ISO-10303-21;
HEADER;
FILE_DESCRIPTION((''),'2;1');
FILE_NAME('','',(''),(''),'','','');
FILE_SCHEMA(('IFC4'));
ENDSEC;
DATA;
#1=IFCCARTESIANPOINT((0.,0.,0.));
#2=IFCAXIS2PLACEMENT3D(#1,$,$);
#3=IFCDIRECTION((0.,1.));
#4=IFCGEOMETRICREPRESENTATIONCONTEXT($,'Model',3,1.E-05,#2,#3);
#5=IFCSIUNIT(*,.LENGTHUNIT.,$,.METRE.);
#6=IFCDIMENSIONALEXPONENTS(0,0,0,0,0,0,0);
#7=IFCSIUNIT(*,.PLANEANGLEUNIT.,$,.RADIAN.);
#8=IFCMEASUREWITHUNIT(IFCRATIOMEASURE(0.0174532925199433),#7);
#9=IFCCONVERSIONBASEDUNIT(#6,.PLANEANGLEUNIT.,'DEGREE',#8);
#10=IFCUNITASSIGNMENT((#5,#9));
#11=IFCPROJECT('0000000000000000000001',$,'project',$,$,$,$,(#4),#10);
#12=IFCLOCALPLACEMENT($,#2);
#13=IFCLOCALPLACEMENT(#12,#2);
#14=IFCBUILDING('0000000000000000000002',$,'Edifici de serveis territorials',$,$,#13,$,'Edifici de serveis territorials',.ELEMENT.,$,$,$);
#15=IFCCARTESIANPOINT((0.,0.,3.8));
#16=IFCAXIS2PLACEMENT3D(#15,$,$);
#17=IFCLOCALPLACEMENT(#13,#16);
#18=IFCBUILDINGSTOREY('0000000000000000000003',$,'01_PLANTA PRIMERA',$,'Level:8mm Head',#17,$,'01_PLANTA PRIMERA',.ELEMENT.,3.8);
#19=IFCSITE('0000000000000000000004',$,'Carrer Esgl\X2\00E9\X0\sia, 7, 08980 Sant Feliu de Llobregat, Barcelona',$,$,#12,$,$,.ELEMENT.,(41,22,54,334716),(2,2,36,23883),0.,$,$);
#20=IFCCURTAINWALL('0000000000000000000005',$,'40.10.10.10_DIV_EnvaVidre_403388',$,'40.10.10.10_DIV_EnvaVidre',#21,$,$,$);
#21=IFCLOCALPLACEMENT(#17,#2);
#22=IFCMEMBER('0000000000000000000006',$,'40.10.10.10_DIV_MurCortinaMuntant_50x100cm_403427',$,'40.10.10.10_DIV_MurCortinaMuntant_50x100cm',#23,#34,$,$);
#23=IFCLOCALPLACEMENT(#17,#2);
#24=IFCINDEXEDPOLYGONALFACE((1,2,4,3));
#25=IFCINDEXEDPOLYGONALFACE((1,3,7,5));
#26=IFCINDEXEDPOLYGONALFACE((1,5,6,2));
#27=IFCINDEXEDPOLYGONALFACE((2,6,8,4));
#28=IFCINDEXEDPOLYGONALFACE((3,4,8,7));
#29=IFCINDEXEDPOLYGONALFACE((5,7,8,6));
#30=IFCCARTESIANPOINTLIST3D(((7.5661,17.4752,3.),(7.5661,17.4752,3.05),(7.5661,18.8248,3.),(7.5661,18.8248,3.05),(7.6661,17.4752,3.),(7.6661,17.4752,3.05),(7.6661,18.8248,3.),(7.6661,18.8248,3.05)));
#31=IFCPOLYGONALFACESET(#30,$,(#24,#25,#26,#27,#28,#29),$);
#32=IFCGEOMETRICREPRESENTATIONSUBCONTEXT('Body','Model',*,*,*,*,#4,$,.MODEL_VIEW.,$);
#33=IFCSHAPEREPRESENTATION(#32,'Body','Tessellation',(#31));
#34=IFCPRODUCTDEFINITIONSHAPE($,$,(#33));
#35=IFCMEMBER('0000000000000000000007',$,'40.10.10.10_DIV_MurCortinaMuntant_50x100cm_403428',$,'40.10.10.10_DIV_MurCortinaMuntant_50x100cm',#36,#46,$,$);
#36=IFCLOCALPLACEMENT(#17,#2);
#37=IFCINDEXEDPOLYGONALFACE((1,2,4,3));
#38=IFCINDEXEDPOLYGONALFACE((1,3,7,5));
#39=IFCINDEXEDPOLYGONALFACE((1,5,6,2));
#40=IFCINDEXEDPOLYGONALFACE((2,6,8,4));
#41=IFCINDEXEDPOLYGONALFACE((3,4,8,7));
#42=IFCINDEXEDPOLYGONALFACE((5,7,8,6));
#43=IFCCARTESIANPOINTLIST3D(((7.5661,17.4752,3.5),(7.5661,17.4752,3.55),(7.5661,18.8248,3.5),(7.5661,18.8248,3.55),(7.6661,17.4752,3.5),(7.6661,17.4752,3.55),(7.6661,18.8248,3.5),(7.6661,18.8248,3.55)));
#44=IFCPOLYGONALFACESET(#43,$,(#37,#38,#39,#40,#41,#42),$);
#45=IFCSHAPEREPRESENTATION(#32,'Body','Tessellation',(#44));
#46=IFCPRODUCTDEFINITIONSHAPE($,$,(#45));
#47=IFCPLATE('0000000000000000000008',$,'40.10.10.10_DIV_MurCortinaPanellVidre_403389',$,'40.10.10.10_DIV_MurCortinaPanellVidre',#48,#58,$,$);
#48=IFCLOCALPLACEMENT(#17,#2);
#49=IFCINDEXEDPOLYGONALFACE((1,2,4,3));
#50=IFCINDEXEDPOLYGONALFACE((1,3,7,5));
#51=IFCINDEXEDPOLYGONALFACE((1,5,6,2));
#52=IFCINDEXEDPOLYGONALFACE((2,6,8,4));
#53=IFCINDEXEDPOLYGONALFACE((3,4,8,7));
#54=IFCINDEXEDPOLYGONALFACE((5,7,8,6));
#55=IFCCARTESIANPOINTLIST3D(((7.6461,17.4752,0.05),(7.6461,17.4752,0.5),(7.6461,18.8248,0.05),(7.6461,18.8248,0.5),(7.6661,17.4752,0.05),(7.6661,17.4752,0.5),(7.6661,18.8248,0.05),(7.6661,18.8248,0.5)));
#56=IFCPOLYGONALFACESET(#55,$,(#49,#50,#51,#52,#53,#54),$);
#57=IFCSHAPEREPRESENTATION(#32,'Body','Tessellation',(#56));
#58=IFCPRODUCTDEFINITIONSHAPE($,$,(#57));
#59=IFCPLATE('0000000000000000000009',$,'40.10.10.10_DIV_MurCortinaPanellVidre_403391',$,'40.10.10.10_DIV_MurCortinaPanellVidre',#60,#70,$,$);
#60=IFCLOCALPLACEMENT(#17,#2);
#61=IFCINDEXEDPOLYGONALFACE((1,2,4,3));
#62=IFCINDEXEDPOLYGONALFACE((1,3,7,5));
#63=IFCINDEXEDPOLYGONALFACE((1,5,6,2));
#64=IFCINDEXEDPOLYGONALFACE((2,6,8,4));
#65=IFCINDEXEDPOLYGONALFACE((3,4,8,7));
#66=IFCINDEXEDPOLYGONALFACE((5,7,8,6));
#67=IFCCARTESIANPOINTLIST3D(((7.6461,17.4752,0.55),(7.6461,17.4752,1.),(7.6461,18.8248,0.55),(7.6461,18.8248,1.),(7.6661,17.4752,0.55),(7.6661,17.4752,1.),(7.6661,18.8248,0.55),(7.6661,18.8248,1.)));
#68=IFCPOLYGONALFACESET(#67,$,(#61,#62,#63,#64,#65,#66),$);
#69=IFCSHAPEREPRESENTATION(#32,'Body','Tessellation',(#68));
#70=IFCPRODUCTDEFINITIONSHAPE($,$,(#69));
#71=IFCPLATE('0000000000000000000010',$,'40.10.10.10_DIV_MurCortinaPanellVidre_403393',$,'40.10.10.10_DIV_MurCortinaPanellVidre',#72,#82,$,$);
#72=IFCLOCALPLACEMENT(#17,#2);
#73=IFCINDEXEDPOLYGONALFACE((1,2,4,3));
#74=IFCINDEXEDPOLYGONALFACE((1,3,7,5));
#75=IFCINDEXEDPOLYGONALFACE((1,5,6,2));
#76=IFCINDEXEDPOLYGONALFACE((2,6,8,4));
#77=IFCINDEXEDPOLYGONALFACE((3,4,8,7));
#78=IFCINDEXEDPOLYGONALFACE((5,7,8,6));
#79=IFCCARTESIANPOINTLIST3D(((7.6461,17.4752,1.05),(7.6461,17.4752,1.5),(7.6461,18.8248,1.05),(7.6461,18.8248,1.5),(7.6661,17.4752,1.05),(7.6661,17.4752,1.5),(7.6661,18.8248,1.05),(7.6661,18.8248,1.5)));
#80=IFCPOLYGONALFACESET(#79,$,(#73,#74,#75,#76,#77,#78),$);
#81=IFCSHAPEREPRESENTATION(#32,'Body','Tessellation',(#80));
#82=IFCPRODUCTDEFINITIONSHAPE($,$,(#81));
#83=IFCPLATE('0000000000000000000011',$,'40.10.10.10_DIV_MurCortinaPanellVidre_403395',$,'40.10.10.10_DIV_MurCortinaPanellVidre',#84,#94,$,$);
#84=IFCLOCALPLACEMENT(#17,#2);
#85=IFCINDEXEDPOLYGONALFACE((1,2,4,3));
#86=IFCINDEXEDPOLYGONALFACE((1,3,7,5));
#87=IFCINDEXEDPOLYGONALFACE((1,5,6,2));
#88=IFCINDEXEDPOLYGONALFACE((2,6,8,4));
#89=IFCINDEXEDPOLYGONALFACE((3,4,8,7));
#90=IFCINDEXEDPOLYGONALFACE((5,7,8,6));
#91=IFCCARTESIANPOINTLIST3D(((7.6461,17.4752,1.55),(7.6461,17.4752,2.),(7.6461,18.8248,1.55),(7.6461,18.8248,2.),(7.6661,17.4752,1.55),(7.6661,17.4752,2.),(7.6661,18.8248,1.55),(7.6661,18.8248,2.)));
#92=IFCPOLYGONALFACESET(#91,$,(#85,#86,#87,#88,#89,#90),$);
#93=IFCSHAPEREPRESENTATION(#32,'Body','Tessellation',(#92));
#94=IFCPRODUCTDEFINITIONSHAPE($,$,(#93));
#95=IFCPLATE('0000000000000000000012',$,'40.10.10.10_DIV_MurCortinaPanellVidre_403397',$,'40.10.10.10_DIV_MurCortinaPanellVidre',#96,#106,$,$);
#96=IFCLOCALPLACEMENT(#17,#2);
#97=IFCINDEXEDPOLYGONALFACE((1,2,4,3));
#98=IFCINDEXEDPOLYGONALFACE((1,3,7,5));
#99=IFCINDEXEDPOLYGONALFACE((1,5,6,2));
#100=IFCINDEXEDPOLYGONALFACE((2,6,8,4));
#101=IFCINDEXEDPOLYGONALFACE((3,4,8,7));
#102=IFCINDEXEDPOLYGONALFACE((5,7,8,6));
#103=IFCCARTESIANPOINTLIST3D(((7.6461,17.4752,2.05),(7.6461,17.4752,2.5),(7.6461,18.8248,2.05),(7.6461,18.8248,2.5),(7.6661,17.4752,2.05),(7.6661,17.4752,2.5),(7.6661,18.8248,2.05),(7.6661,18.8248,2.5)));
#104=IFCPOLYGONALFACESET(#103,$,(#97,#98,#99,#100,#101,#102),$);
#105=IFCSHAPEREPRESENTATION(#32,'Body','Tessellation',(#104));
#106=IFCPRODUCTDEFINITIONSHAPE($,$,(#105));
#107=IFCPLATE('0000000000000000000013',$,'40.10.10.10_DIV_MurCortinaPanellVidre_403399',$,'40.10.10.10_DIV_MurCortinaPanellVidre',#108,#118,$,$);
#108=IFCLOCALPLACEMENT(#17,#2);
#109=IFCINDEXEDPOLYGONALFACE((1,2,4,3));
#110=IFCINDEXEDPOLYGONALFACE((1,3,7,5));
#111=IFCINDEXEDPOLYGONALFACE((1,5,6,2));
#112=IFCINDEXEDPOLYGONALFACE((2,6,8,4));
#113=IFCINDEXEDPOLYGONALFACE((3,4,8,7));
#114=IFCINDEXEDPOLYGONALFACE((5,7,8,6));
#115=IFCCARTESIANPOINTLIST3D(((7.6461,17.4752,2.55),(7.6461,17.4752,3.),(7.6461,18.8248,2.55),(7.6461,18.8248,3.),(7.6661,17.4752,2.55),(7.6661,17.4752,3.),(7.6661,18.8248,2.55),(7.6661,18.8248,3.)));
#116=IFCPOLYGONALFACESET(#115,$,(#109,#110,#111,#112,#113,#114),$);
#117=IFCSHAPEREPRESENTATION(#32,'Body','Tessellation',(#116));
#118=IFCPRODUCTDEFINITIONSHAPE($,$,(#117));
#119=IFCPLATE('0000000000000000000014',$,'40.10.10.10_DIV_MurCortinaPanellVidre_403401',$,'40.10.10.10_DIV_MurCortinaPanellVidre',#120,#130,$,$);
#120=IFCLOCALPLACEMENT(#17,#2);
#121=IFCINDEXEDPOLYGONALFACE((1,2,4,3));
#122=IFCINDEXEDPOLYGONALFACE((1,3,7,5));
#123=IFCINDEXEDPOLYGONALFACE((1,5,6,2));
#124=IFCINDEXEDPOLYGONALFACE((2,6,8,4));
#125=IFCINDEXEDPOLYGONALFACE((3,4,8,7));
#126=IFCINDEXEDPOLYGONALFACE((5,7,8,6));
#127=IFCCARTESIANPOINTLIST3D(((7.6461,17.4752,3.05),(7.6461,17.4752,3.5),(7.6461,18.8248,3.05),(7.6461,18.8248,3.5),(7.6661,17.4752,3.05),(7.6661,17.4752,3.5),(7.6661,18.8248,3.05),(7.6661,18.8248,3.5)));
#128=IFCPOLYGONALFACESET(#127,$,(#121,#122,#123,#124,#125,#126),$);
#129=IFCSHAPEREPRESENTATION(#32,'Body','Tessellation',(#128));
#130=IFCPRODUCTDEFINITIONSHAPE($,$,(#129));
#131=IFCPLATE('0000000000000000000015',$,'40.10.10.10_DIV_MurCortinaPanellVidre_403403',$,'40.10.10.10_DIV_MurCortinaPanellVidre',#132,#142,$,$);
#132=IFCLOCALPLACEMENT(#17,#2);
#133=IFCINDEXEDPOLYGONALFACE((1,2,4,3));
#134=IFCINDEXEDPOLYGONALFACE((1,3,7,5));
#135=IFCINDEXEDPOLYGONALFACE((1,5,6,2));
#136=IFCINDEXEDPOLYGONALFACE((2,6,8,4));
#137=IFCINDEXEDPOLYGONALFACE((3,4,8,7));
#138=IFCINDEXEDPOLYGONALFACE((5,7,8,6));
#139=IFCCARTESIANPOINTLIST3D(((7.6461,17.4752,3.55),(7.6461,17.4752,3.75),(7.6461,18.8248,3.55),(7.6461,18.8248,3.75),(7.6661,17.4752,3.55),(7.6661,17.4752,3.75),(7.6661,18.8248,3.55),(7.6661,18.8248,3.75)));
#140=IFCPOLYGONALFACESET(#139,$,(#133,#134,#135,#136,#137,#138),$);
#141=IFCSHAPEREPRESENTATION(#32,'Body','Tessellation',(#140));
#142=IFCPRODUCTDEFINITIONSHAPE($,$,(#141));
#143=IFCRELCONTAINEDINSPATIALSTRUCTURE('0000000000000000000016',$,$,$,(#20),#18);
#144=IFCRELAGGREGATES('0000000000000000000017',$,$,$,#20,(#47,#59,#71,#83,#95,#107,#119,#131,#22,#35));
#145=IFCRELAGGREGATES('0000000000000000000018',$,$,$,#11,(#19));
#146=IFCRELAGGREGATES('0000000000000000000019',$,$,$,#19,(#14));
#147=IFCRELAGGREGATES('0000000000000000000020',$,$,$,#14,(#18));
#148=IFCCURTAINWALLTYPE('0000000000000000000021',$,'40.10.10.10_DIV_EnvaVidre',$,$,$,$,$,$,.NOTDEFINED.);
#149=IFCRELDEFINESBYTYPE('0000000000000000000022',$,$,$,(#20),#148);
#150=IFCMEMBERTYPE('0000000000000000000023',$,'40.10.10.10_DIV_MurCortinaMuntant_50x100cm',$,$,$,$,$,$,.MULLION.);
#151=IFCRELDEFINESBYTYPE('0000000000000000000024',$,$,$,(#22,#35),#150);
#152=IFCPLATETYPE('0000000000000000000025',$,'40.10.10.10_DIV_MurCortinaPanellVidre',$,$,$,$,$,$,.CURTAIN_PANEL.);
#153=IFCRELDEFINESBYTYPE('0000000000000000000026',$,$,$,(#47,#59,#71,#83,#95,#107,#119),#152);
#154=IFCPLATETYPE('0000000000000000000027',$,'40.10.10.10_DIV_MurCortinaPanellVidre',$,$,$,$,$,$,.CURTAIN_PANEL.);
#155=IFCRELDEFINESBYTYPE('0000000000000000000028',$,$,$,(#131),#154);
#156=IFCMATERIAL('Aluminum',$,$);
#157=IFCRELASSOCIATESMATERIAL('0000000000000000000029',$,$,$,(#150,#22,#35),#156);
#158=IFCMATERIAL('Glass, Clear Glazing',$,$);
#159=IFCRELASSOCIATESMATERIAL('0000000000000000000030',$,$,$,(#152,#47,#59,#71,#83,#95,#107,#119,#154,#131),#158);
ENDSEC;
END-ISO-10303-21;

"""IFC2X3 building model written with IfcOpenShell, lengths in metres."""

from ifc_helpers import new_model, entity, si_unit, converted_unit, direction, frame, frame_2d, origin, origin_2d_with_axis, place, context, subcontext, project, spatial, rectangle, extrude, source, transform, mapped, material, type_object, type_shapes, element, aggregate, save


model = new_model("IFC2X3")

# Units and contexts
model_context = context("Model", 3, precision=1e-05, world=origin(), true_north=direction((0.0, 1.0)))
body_context = subcontext(model_context, "Body", "Model", "MODEL_VIEW")
ifc_project = project(units=[si_unit("LENGTHUNIT", "METRE"), converted_unit("PLANEANGLEUNIT", "DEGREE", entity("IfcRatioMeasure", 0.0174532925199433), si_unit("PLANEANGLEUNIT", "RADIAN"), dimensions=[0, 0, 0, 0, 0, 0, 0])], contexts=[model_context])

# Site, building, storey
site_placement = place(None, origin())
site = spatial("IfcSite", under=ifc_project, at=site_placement, Name="Carrer Església, 7, 08980 Sant Feliu de Llobregat, Barcelona", CompositionType="ELEMENT", RefLatitude=(41, 22, 54, 334716), RefLongitude=(2, 2, 36, 23883), RefElevation=0.0)
building_placement = place(site_placement, origin())
building = spatial("IfcBuilding", under=site, at=building_placement, Name="Edifici de serveis territorials", LongName="Edifici de serveis territorials", CompositionType="ELEMENT")
storey_placement = place(building_placement, frame((0.0, 0.0, 3.8)))
storey = spatial("IfcBuildingStorey", under=building, at=storey_placement, Name="01_PLANTA PRIMERA", ObjectType="Level:8mm Head", LongName="01_PLANTA PRIMERA", CompositionType="ELEMENT", Elevation=3.8)

# Shared definitions
curtain_wall_type = type_object("IfcCurtainWallType", Name="40.10.10.10_DIV_EnvaVidre", PredefinedType="NOTDEFINED")
ifc_material_1 = material(Name="Aluminum")

# Curtain wall, members, plates
curtain_wall_1_placement = place(storey_placement, frame((0.0, 0.0, -3.8)))
curtain_wall_1 = element("IfcCurtainWall", 1, at=curtain_wall_1_placement, inside=storey, type_object=curtain_wall_type, Name="40.10.10.10_DIV_EnvaVidre_403388", ObjectType="40.10.10.10_DIV_EnvaVidre")
member_type_1 = type_object("IfcMemberType", Name="40.10.10.10_DIV_MurCortinaMuntant_50x100cm", PredefinedType="MULLION", material=ifc_material_1)
shared_shape_1 = source(origin(), body_context, "Body", "SweptSolid", [
    extrude(rectangle(XDim=0.1, YDim=0.05, at=origin_2d_with_axis()), frame((0.0, 0.0, -1.3496), z_axis=(0.0, 0.0, 1.0), x_axis=(0.0, -1.0, 0.0)), (0.0, 0.0, 1.0), 1.3496),
])
type_shapes(member_type_1, [shared_shape_1])
member_1_placement = place(storey_placement, frame((7.6161, 17.4752, 3.025), z_axis=(0.0, -1.0, 0.0), x_axis=(0.0, 0.0, 1.0)))
member_1 = element("IfcMember", 2, at=member_1_placement, type_object=member_type_1, material=ifc_material_1, Name="40.10.10.10_DIV_MurCortinaMuntant_50x100cm_403427", ObjectType="40.10.10.10_DIV_MurCortinaMuntant_50x100cm", context=body_context, shape_type="MappedRepresentation", body=[
    mapped(shared_shape_1, transform((0.0, 0.0, 0.0), scale=1.0)),
])
member_2_placement = place(storey_placement, frame((7.6161, 17.4752, 3.525), z_axis=(0.0, -1.0, 0.0), x_axis=(0.0, 0.0, 1.0)))
member_2 = element("IfcMember", 3, at=member_2_placement, type_object=member_type_1, material=ifc_material_1, Name="40.10.10.10_DIV_MurCortinaMuntant_50x100cm_403428", ObjectType="40.10.10.10_DIV_MurCortinaMuntant_50x100cm", context=body_context, shape_type="MappedRepresentation", body=[
    mapped(shared_shape_1, transform((0.0, 0.0, 0.0), scale=1.0)),
])
ifc_material_2 = material(Name="Glass, Clear Glazing")
plate_type_1 = type_object("IfcPlateType", Name="40.10.10.10_DIV_MurCortinaPanellVidre", PredefinedType="CURTAIN_PANEL", material=ifc_material_2)
shared_shape_2 = source(origin(), body_context, "Body", "SweptSolid", [
    extrude(rectangle(XDim=0.02, YDim=1.3496, at=frame_2d((0.0, 0.0), x_axis=(1.0, 0.0))), frame((0.6748, 0.01, 0.0), z_axis=(0.0, 0.0, 1.0), x_axis=(0.0, 1.0, 0.0)), (0.0, 0.0, 1.0), 0.45),
])
type_shapes(plate_type_1, [shared_shape_2])
plate_1_placement = place(curtain_wall_1_placement, frame((7.6461, 18.8248, 3.85), z_axis=(0.0, 0.0, 1.0), x_axis=(0.0, -1.0, 0.0)))
plate_1 = element("IfcPlate", 4, at=plate_1_placement, type_object=plate_type_1, material=ifc_material_2, Name="40.10.10.10_DIV_MurCortinaPanellVidre_403389", ObjectType="40.10.10.10_DIV_MurCortinaPanellVidre", context=body_context, shape_type="MappedRepresentation", body=[
    mapped(shared_shape_2, transform((0.0, 0.0, 0.0), scale=1.0)),
])
plate_2_placement = place(curtain_wall_1_placement, frame((7.6461, 18.8248, 4.35), z_axis=(0.0, 0.0, 1.0), x_axis=(0.0, -1.0, 0.0)))
plate_2 = element("IfcPlate", 5, at=plate_2_placement, type_object=plate_type_1, material=ifc_material_2, Name="40.10.10.10_DIV_MurCortinaPanellVidre_403391", ObjectType="40.10.10.10_DIV_MurCortinaPanellVidre", context=body_context, shape_type="MappedRepresentation", body=[
    mapped(shared_shape_2, transform((0.0, 0.0, 0.0), scale=1.0)),
])
plate_3_placement = place(curtain_wall_1_placement, frame((7.6461, 18.8248, 4.85), z_axis=(0.0, 0.0, 1.0), x_axis=(0.0, -1.0, 0.0)))
plate_3 = element("IfcPlate", 6, at=plate_3_placement, type_object=plate_type_1, material=ifc_material_2, Name="40.10.10.10_DIV_MurCortinaPanellVidre_403393", ObjectType="40.10.10.10_DIV_MurCortinaPanellVidre", context=body_context, shape_type="MappedRepresentation", body=[
    mapped(shared_shape_2, transform((0.0, 0.0, 0.0), scale=1.0)),
])
plate_4_placement = place(curtain_wall_1_placement, frame((7.6461, 18.8248, 5.35), z_axis=(0.0, 0.0, 1.0), x_axis=(0.0, -1.0, 0.0)))
plate_4 = element("IfcPlate", 7, at=plate_4_placement, type_object=plate_type_1, material=ifc_material_2, Name="40.10.10.10_DIV_MurCortinaPanellVidre_403395", ObjectType="40.10.10.10_DIV_MurCortinaPanellVidre", context=body_context, shape_type="MappedRepresentation", body=[
    mapped(shared_shape_2, transform((0.0, 0.0, 0.0), scale=1.0)),
])
plate_5_placement = place(curtain_wall_1_placement, frame((7.6461, 18.8248, 5.85), z_axis=(0.0, 0.0, 1.0), x_axis=(0.0, -1.0, 0.0)))
plate_5 = element("IfcPlate", 8, at=plate_5_placement, type_object=plate_type_1, material=ifc_material_2, Name="40.10.10.10_DIV_MurCortinaPanellVidre_403397", ObjectType="40.10.10.10_DIV_MurCortinaPanellVidre", context=body_context, shape_type="MappedRepresentation", body=[
    mapped(shared_shape_2, transform((0.0, 0.0, 0.0), scale=1.0)),
])
plate_6_placement = place(curtain_wall_1_placement, frame((7.6461, 18.8248, 6.35), z_axis=(0.0, 0.0, 1.0), x_axis=(0.0, -1.0, 0.0)))
plate_6 = element("IfcPlate", 9, at=plate_6_placement, type_object=plate_type_1, material=ifc_material_2, Name="40.10.10.10_DIV_MurCortinaPanellVidre_403399", ObjectType="40.10.10.10_DIV_MurCortinaPanellVidre", context=body_context, shape_type="MappedRepresentation", body=[
    mapped(shared_shape_2, transform((0.0, 0.0, 0.0), scale=1.0)),
])
plate_7_placement = place(curtain_wall_1_placement, frame((7.6461, 18.8248, 6.85), z_axis=(0.0, 0.0, 1.0), x_axis=(0.0, -1.0, 0.0)))
plate_7 = element("IfcPlate", 10, at=plate_7_placement, type_object=plate_type_1, material=ifc_material_2, Name="40.10.10.10_DIV_MurCortinaPanellVidre_403401", ObjectType="40.10.10.10_DIV_MurCortinaPanellVidre", context=body_context, shape_type="MappedRepresentation", body=[
    mapped(shared_shape_2, transform((0.0, 0.0, 0.0), scale=1.0)),
])
plate_type_2 = type_object("IfcPlateType", Name="40.10.10.10_DIV_MurCortinaPanellVidre", PredefinedType="CURTAIN_PANEL", material=ifc_material_2)
shared_shape_3 = source(origin(), body_context, "Body", "SweptSolid", [
    extrude(rectangle(XDim=0.02, YDim=1.3496, at=frame_2d((0.0, 0.0), x_axis=(1.0, 0.0))), frame((0.6748, 0.01, 0.0), z_axis=(0.0, 0.0, 1.0), x_axis=(0.0, 1.0, 0.0)), (0.0, 0.0, 1.0), 0.2),
])
type_shapes(plate_type_2, [shared_shape_3])
plate_8_placement = place(curtain_wall_1_placement, frame((7.6461, 18.8248, 7.35), z_axis=(0.0, 0.0, 1.0), x_axis=(0.0, -1.0, 0.0)))
plate_8 = element("IfcPlate", 11, at=plate_8_placement, type_object=plate_type_2, material=ifc_material_2, Name="40.10.10.10_DIV_MurCortinaPanellVidre_403403", ObjectType="40.10.10.10_DIV_MurCortinaPanellVidre", context=body_context, shape_type="MappedRepresentation", body=[
    mapped(shared_shape_3, transform((0.0, 0.0, 0.0), scale=1.0)),
])
aggregate(curtain_wall_1, [plate_1, plate_2, plate_3, plate_4, plate_5, plate_6, plate_7, plate_8, member_1, member_2])

save(model, "model.ifc")
